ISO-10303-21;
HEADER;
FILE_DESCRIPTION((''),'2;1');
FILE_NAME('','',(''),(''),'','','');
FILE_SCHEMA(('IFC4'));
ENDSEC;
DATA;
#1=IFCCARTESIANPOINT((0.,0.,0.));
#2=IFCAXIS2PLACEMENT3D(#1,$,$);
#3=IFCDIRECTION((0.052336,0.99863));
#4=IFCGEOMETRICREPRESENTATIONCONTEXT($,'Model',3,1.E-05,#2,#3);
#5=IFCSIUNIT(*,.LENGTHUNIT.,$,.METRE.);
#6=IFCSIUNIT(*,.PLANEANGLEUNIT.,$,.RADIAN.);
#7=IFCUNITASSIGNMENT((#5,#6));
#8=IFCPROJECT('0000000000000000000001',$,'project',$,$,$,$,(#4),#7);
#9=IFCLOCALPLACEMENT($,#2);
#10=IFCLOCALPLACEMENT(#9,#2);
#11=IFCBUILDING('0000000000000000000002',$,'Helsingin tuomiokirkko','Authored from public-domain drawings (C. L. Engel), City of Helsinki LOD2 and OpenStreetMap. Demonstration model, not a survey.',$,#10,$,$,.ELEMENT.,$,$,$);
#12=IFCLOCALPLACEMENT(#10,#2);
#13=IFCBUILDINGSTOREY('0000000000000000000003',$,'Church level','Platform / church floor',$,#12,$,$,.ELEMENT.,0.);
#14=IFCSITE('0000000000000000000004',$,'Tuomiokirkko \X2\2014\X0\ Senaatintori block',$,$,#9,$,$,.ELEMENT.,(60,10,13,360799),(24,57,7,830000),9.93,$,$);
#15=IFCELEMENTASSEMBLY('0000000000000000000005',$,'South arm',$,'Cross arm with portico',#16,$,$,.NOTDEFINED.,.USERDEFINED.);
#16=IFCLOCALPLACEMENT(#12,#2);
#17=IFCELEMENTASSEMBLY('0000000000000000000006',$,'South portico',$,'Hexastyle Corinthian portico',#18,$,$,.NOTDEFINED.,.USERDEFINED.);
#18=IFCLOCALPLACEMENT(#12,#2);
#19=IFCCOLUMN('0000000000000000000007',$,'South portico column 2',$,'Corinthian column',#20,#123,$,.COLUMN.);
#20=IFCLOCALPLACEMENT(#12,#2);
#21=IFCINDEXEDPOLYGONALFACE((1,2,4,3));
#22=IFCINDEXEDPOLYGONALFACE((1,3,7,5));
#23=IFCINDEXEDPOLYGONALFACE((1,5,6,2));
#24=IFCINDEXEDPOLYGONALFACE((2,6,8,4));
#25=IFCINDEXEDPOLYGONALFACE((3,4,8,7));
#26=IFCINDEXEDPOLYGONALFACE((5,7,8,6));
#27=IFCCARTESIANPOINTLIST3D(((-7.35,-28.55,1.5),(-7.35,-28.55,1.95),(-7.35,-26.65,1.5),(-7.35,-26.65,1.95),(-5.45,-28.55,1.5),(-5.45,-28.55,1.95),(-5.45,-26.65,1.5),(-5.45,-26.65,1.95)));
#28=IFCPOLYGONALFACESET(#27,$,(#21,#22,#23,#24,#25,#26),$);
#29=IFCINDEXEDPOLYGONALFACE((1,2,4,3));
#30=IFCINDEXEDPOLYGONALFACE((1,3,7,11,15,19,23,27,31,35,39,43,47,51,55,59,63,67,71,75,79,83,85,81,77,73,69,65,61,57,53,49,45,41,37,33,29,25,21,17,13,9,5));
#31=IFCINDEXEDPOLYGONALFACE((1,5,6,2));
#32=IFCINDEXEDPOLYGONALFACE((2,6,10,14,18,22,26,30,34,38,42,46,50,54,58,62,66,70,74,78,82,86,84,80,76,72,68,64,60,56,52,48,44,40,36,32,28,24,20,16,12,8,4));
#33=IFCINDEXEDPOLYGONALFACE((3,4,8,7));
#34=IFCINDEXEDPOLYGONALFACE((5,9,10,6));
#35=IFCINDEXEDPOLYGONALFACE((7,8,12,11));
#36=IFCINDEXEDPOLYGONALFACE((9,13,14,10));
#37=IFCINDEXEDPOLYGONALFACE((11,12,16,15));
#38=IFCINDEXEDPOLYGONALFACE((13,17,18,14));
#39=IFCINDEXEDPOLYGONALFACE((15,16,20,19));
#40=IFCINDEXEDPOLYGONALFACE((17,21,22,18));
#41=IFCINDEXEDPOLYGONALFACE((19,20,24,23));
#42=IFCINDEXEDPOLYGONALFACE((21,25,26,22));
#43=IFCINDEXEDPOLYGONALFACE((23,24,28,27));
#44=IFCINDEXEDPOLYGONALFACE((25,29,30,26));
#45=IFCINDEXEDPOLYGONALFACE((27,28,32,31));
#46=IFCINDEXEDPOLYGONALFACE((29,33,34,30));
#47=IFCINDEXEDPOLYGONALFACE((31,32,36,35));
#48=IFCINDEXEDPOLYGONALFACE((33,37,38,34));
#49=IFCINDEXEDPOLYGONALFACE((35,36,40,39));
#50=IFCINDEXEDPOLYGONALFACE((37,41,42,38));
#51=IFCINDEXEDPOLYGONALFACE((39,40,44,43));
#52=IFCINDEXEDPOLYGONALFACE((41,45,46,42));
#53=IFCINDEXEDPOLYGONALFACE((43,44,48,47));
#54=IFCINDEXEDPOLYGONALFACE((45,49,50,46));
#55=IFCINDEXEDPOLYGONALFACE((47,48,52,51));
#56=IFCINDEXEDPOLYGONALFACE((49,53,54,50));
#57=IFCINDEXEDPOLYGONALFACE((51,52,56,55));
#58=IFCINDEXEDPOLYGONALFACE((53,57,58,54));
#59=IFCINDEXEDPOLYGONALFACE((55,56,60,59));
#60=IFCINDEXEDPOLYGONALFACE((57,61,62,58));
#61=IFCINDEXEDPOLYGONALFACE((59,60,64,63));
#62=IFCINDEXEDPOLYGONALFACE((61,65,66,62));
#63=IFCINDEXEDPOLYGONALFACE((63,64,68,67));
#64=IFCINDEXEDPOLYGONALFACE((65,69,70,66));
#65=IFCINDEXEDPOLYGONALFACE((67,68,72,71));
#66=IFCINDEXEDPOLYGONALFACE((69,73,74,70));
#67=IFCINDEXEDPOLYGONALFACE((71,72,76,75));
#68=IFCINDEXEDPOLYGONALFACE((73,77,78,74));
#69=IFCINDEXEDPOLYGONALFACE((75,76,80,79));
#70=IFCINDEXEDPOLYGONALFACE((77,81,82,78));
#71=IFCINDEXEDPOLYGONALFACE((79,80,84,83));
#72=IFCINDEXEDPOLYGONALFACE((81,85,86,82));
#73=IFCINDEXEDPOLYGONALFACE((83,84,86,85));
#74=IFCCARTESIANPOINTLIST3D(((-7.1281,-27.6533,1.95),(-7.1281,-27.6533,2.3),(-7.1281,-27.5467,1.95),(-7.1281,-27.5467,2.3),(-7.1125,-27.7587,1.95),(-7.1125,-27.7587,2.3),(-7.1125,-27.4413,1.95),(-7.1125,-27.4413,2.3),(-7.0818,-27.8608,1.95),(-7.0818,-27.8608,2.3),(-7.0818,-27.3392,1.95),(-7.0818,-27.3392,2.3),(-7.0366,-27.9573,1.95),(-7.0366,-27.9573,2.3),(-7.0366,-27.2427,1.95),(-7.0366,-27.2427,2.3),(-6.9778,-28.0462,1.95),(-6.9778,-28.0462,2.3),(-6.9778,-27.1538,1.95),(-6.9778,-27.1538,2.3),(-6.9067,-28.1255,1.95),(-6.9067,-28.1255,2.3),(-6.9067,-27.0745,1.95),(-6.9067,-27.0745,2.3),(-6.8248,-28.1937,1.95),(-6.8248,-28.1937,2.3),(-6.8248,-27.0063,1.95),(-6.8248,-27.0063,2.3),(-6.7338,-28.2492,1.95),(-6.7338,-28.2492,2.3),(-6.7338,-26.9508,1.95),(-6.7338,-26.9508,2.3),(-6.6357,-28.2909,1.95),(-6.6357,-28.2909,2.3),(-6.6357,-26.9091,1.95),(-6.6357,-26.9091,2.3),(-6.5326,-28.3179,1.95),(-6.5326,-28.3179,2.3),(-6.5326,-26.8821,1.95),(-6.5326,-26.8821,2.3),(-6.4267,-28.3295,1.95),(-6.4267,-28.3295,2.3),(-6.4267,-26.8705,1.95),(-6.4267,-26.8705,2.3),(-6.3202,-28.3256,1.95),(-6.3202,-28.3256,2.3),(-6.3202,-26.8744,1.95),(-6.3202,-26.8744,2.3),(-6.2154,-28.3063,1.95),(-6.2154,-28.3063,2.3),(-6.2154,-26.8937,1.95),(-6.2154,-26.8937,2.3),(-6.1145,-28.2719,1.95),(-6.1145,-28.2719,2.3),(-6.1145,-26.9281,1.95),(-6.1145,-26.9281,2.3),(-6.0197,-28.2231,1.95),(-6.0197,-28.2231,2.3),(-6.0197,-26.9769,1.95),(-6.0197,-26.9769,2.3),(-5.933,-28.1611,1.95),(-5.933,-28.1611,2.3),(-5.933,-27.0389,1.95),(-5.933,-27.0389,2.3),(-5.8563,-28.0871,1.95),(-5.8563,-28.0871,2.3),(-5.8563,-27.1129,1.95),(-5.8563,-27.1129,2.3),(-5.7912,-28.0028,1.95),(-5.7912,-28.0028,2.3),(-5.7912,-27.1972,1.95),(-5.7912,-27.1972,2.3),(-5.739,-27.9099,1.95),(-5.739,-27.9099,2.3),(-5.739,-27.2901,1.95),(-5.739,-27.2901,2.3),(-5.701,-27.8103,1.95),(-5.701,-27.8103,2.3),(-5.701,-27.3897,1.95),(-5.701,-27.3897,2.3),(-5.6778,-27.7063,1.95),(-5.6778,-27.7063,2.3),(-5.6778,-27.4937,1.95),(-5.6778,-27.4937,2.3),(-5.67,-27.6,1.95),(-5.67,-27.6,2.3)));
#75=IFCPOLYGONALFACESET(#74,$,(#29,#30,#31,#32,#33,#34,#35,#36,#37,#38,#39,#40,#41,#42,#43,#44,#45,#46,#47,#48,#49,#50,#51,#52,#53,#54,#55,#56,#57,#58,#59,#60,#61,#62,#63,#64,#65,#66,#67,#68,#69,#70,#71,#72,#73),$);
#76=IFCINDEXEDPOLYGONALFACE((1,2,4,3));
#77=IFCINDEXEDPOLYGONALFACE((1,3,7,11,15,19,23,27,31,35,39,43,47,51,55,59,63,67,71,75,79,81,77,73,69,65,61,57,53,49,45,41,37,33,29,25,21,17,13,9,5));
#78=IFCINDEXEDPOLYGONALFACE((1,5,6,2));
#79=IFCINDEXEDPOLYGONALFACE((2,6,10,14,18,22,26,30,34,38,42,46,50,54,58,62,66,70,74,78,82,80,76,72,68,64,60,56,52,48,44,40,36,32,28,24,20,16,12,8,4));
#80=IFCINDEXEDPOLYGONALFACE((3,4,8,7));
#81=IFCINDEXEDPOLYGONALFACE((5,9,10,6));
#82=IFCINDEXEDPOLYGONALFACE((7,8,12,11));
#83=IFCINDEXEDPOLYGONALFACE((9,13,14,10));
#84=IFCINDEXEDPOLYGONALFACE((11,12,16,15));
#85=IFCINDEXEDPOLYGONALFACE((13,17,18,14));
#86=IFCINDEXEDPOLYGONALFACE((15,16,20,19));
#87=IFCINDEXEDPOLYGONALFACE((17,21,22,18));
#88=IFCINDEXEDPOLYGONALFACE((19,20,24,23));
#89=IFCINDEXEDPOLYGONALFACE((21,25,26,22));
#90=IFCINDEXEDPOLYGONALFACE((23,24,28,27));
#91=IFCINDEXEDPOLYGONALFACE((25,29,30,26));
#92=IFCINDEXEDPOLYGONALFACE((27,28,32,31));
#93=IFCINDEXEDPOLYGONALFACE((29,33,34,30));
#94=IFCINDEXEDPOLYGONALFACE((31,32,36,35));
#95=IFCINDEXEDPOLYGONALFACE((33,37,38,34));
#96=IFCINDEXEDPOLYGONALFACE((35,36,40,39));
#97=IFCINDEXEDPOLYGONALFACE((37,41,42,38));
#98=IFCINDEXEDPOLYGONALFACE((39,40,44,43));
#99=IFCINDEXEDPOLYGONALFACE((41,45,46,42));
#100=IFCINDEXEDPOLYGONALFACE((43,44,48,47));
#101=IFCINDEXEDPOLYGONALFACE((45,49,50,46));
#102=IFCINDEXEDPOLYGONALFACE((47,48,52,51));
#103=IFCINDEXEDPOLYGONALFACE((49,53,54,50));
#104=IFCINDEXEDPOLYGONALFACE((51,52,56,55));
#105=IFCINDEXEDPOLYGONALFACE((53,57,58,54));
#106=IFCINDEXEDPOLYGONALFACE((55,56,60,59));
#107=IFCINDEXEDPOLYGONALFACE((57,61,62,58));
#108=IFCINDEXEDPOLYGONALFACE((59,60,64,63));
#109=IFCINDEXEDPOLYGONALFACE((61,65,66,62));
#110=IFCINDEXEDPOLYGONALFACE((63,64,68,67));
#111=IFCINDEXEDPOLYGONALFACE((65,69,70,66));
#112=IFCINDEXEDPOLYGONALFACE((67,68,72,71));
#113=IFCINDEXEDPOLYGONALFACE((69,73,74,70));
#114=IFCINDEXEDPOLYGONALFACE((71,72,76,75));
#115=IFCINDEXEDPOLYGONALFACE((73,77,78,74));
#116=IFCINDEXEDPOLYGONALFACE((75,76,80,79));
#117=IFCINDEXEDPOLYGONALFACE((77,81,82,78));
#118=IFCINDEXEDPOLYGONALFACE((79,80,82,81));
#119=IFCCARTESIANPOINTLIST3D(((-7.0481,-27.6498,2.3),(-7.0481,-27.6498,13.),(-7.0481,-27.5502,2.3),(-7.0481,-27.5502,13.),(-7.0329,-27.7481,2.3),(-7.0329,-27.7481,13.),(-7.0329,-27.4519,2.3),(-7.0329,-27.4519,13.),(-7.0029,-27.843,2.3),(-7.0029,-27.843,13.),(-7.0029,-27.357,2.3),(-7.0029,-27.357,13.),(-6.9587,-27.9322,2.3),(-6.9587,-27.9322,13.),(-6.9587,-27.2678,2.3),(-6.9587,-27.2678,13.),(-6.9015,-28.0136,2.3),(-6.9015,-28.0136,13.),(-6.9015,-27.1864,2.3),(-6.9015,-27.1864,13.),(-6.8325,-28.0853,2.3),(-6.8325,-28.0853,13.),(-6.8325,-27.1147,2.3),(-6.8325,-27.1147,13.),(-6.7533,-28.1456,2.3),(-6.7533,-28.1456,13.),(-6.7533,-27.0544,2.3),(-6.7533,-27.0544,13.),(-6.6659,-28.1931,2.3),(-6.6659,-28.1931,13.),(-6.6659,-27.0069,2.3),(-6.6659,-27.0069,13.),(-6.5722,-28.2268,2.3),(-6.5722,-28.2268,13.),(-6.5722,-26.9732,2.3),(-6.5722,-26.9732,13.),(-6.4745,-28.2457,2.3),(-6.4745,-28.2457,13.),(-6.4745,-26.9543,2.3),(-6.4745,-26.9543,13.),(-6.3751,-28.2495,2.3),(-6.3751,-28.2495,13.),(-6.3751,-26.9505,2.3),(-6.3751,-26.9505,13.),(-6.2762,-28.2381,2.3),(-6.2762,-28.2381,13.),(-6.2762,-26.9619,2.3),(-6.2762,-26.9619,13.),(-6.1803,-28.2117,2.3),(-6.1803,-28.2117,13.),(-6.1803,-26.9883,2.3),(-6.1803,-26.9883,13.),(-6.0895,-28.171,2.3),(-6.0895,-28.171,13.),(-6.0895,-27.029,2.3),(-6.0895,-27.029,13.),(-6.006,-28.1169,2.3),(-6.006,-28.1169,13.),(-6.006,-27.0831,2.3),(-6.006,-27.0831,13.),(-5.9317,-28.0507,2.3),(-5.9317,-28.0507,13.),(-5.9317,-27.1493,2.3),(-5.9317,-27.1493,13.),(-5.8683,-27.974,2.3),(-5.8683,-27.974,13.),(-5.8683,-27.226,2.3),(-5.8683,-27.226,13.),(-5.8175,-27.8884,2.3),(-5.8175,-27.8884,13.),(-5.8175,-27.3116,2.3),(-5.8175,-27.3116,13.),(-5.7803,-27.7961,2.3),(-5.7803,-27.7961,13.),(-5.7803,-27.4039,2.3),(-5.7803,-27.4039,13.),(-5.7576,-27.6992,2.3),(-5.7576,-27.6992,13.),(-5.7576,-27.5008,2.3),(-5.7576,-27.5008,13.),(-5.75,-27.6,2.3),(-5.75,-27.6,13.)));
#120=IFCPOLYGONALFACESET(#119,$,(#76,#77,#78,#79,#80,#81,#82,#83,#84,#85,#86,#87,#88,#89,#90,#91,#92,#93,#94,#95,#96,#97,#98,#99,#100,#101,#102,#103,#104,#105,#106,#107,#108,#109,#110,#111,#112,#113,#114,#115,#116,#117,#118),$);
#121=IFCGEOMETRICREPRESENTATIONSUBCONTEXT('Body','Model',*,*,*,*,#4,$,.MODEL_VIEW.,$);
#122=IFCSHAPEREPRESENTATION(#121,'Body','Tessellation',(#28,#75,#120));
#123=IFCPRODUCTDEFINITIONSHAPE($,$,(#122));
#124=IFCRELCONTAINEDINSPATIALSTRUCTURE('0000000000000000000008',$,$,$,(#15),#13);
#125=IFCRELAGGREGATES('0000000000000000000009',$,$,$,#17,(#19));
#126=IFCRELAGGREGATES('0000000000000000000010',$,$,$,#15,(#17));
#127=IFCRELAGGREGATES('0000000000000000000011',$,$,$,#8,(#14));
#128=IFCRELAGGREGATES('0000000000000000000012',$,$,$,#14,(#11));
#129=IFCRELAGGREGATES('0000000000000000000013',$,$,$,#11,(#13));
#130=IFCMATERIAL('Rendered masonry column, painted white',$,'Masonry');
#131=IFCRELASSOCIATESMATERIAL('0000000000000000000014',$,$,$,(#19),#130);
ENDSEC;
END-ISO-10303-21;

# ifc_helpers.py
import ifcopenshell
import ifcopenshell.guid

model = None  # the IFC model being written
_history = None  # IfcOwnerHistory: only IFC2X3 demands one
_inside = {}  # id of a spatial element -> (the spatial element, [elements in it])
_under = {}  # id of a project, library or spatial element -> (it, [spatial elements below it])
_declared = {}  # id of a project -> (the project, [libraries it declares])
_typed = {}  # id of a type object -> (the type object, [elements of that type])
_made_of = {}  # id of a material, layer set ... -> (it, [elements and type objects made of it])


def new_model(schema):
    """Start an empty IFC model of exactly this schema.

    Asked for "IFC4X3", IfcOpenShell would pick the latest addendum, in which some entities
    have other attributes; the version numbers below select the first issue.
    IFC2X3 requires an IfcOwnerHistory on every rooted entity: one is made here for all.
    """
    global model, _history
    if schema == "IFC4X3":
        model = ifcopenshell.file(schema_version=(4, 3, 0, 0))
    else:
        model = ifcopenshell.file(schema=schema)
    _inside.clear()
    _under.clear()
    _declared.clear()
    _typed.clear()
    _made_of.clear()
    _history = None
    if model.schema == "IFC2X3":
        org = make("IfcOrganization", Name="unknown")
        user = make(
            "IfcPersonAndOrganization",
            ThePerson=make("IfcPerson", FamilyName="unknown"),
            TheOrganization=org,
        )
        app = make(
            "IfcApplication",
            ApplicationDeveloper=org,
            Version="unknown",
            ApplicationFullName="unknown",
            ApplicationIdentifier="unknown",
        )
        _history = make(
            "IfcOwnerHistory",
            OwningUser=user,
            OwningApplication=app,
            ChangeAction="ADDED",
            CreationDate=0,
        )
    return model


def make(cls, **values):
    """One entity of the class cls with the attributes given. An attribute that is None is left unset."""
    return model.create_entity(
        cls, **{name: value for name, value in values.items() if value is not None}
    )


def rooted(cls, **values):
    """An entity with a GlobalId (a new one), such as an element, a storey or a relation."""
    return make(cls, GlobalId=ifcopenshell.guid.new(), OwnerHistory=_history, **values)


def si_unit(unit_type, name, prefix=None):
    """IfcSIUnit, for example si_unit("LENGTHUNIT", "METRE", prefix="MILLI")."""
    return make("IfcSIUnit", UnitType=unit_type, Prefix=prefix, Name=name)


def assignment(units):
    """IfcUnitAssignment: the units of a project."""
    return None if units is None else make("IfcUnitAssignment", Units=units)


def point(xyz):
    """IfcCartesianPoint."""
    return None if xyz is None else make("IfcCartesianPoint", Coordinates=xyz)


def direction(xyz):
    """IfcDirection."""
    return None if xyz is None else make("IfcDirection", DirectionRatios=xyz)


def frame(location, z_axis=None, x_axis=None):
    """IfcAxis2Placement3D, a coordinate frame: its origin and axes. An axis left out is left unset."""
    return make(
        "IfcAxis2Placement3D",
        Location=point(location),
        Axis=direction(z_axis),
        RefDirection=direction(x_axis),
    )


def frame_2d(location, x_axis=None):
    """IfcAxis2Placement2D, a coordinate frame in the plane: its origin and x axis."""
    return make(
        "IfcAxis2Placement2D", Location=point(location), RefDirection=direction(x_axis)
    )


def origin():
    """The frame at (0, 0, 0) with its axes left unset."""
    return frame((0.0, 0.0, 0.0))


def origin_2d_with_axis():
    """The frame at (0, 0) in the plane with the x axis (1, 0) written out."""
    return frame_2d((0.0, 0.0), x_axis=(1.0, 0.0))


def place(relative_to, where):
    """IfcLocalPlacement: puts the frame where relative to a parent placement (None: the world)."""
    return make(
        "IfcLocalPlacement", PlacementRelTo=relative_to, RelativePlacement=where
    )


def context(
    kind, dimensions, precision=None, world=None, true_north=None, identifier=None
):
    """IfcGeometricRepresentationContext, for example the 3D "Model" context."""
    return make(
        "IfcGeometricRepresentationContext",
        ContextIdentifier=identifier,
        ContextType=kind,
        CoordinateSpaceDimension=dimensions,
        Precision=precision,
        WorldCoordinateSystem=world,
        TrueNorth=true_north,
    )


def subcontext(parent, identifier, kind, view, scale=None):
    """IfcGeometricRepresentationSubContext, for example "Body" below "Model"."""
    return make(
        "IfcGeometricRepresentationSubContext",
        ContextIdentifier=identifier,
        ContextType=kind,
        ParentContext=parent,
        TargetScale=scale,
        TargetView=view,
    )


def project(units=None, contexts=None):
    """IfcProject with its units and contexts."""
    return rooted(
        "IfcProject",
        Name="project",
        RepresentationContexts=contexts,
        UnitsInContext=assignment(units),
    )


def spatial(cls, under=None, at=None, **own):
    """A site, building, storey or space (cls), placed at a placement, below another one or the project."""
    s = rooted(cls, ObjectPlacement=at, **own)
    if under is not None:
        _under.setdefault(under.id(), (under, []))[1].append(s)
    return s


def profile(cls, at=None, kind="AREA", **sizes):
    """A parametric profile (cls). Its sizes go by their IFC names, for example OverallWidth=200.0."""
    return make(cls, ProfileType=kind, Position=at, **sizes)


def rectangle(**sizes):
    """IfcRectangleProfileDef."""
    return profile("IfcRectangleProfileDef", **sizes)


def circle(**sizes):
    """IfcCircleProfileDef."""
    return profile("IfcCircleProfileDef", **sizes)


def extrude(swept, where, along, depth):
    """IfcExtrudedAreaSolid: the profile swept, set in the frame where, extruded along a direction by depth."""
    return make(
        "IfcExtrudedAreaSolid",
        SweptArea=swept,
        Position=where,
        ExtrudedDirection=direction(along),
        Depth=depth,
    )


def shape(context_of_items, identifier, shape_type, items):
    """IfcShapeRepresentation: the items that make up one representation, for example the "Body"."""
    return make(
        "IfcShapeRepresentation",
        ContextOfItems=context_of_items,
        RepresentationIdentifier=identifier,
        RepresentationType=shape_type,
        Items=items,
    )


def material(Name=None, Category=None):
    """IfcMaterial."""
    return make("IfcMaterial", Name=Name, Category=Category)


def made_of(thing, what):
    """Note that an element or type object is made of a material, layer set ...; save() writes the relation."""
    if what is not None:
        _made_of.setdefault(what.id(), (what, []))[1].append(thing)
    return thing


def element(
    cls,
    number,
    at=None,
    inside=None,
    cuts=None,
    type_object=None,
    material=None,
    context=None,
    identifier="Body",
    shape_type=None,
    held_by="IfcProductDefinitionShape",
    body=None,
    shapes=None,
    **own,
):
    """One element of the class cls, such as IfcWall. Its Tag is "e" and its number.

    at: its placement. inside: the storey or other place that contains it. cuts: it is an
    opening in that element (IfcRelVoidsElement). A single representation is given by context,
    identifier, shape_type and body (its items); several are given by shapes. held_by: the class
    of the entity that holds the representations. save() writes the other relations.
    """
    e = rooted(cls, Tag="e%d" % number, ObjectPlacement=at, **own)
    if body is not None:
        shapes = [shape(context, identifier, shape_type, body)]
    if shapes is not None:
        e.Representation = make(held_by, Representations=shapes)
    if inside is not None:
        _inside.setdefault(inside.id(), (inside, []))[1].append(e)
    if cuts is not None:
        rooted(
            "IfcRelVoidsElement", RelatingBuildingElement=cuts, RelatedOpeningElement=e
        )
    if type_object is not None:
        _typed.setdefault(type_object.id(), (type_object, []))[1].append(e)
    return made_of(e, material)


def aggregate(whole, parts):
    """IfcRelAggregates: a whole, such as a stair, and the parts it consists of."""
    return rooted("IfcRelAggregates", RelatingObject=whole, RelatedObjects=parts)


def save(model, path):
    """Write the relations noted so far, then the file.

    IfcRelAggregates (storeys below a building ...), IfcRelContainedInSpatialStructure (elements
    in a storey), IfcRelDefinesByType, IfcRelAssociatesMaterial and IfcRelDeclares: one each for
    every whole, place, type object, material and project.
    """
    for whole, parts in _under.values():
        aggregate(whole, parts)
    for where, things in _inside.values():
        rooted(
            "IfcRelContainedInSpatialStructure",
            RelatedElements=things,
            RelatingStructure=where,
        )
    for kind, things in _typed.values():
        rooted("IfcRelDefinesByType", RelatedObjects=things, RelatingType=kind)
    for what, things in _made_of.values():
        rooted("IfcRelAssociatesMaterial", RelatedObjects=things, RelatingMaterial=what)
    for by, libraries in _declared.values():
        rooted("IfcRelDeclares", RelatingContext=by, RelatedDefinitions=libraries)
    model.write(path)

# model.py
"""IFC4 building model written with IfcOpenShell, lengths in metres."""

from ifc_helpers import new_model, si_unit, direction, frame, origin, origin_2d_with_axis, place, context, subcontext, project, spatial, rectangle, circle, extrude, material, element, aggregate, save


model = new_model("IFC4")

# Units and contexts
model_context = context("Model", 3, precision=1e-05, world=origin(), true_north=direction((0.052336, 0.99863)))
body_context = subcontext(model_context, "Body", "Model", "MODEL_VIEW")
ifc_project = project(units=[si_unit("LENGTHUNIT", "METRE"), si_unit("PLANEANGLEUNIT", "RADIAN")], contexts=[model_context])

# Site, building, storey
site_placement = place(None, origin())
site = spatial("IfcSite", under=ifc_project, at=site_placement, Name="Tuomiokirkko — Senaatintori block", CompositionType="ELEMENT", RefLatitude=(60, 10, 13, 360799), RefLongitude=(24, 57, 7, 830000), RefElevation=9.93)
building_placement = place(site_placement, origin())
building = spatial("IfcBuilding", under=site, at=building_placement, Name="Helsingin tuomiokirkko", Description="Authored from public-domain drawings (C. L. Engel), City of Helsinki LOD2 and OpenStreetMap. Demonstration model, not a survey.", CompositionType="ELEMENT")
storey_placement = place(building_placement, origin())
storey = spatial("IfcBuildingStorey", under=building, at=storey_placement, Name="Church level", Description="Platform / church floor", CompositionType="ELEMENT", Elevation=0.0)

# Element assemblies, column
assembly_1_placement = place(building_placement, origin())
assembly_1 = element("IfcElementAssembly", 1, at=assembly_1_placement, inside=storey, Name="South arm", ObjectType="Cross arm with portico", AssemblyPlace="NOTDEFINED", PredefinedType="USERDEFINED")
assembly_2_placement = place(building_placement, origin())
assembly_2 = element("IfcElementAssembly", 2, at=assembly_2_placement, Name="South portico", ObjectType="Hexastyle Corinthian portico", AssemblyPlace="NOTDEFINED", PredefinedType="USERDEFINED")
ifc_material_1 = material(Name="Rendered masonry column, painted white", Category="Masonry")
column_1_placement = place(building_placement, origin())
column_1 = element("IfcColumn", 3, at=column_1_placement, material=ifc_material_1, Name="South portico column 2", ObjectType="Corinthian column", PredefinedType="COLUMN", context=body_context, shape_type="SweptSolid", body=[
    extrude(rectangle(XDim=1.9, YDim=1.9, at=origin_2d_with_axis()), frame((-6.4, -27.6, 1.5)), (0.0, 0.0, 1.0), 0.45),
    extrude(circle(Radius=0.73, at=origin_2d_with_axis()), frame((-6.4, -27.6, 1.95)), (0.0, 0.0, 1.0), 0.35),
    extrude(circle(Radius=0.65, at=origin_2d_with_axis()), frame((-6.4, -27.6, 2.3)), (0.0, 0.0, 1.0), 10.7),
])
aggregate(assembly_2, [column_1])
aggregate(assembly_1, [assembly_2])

save(model, "model.ifc")
